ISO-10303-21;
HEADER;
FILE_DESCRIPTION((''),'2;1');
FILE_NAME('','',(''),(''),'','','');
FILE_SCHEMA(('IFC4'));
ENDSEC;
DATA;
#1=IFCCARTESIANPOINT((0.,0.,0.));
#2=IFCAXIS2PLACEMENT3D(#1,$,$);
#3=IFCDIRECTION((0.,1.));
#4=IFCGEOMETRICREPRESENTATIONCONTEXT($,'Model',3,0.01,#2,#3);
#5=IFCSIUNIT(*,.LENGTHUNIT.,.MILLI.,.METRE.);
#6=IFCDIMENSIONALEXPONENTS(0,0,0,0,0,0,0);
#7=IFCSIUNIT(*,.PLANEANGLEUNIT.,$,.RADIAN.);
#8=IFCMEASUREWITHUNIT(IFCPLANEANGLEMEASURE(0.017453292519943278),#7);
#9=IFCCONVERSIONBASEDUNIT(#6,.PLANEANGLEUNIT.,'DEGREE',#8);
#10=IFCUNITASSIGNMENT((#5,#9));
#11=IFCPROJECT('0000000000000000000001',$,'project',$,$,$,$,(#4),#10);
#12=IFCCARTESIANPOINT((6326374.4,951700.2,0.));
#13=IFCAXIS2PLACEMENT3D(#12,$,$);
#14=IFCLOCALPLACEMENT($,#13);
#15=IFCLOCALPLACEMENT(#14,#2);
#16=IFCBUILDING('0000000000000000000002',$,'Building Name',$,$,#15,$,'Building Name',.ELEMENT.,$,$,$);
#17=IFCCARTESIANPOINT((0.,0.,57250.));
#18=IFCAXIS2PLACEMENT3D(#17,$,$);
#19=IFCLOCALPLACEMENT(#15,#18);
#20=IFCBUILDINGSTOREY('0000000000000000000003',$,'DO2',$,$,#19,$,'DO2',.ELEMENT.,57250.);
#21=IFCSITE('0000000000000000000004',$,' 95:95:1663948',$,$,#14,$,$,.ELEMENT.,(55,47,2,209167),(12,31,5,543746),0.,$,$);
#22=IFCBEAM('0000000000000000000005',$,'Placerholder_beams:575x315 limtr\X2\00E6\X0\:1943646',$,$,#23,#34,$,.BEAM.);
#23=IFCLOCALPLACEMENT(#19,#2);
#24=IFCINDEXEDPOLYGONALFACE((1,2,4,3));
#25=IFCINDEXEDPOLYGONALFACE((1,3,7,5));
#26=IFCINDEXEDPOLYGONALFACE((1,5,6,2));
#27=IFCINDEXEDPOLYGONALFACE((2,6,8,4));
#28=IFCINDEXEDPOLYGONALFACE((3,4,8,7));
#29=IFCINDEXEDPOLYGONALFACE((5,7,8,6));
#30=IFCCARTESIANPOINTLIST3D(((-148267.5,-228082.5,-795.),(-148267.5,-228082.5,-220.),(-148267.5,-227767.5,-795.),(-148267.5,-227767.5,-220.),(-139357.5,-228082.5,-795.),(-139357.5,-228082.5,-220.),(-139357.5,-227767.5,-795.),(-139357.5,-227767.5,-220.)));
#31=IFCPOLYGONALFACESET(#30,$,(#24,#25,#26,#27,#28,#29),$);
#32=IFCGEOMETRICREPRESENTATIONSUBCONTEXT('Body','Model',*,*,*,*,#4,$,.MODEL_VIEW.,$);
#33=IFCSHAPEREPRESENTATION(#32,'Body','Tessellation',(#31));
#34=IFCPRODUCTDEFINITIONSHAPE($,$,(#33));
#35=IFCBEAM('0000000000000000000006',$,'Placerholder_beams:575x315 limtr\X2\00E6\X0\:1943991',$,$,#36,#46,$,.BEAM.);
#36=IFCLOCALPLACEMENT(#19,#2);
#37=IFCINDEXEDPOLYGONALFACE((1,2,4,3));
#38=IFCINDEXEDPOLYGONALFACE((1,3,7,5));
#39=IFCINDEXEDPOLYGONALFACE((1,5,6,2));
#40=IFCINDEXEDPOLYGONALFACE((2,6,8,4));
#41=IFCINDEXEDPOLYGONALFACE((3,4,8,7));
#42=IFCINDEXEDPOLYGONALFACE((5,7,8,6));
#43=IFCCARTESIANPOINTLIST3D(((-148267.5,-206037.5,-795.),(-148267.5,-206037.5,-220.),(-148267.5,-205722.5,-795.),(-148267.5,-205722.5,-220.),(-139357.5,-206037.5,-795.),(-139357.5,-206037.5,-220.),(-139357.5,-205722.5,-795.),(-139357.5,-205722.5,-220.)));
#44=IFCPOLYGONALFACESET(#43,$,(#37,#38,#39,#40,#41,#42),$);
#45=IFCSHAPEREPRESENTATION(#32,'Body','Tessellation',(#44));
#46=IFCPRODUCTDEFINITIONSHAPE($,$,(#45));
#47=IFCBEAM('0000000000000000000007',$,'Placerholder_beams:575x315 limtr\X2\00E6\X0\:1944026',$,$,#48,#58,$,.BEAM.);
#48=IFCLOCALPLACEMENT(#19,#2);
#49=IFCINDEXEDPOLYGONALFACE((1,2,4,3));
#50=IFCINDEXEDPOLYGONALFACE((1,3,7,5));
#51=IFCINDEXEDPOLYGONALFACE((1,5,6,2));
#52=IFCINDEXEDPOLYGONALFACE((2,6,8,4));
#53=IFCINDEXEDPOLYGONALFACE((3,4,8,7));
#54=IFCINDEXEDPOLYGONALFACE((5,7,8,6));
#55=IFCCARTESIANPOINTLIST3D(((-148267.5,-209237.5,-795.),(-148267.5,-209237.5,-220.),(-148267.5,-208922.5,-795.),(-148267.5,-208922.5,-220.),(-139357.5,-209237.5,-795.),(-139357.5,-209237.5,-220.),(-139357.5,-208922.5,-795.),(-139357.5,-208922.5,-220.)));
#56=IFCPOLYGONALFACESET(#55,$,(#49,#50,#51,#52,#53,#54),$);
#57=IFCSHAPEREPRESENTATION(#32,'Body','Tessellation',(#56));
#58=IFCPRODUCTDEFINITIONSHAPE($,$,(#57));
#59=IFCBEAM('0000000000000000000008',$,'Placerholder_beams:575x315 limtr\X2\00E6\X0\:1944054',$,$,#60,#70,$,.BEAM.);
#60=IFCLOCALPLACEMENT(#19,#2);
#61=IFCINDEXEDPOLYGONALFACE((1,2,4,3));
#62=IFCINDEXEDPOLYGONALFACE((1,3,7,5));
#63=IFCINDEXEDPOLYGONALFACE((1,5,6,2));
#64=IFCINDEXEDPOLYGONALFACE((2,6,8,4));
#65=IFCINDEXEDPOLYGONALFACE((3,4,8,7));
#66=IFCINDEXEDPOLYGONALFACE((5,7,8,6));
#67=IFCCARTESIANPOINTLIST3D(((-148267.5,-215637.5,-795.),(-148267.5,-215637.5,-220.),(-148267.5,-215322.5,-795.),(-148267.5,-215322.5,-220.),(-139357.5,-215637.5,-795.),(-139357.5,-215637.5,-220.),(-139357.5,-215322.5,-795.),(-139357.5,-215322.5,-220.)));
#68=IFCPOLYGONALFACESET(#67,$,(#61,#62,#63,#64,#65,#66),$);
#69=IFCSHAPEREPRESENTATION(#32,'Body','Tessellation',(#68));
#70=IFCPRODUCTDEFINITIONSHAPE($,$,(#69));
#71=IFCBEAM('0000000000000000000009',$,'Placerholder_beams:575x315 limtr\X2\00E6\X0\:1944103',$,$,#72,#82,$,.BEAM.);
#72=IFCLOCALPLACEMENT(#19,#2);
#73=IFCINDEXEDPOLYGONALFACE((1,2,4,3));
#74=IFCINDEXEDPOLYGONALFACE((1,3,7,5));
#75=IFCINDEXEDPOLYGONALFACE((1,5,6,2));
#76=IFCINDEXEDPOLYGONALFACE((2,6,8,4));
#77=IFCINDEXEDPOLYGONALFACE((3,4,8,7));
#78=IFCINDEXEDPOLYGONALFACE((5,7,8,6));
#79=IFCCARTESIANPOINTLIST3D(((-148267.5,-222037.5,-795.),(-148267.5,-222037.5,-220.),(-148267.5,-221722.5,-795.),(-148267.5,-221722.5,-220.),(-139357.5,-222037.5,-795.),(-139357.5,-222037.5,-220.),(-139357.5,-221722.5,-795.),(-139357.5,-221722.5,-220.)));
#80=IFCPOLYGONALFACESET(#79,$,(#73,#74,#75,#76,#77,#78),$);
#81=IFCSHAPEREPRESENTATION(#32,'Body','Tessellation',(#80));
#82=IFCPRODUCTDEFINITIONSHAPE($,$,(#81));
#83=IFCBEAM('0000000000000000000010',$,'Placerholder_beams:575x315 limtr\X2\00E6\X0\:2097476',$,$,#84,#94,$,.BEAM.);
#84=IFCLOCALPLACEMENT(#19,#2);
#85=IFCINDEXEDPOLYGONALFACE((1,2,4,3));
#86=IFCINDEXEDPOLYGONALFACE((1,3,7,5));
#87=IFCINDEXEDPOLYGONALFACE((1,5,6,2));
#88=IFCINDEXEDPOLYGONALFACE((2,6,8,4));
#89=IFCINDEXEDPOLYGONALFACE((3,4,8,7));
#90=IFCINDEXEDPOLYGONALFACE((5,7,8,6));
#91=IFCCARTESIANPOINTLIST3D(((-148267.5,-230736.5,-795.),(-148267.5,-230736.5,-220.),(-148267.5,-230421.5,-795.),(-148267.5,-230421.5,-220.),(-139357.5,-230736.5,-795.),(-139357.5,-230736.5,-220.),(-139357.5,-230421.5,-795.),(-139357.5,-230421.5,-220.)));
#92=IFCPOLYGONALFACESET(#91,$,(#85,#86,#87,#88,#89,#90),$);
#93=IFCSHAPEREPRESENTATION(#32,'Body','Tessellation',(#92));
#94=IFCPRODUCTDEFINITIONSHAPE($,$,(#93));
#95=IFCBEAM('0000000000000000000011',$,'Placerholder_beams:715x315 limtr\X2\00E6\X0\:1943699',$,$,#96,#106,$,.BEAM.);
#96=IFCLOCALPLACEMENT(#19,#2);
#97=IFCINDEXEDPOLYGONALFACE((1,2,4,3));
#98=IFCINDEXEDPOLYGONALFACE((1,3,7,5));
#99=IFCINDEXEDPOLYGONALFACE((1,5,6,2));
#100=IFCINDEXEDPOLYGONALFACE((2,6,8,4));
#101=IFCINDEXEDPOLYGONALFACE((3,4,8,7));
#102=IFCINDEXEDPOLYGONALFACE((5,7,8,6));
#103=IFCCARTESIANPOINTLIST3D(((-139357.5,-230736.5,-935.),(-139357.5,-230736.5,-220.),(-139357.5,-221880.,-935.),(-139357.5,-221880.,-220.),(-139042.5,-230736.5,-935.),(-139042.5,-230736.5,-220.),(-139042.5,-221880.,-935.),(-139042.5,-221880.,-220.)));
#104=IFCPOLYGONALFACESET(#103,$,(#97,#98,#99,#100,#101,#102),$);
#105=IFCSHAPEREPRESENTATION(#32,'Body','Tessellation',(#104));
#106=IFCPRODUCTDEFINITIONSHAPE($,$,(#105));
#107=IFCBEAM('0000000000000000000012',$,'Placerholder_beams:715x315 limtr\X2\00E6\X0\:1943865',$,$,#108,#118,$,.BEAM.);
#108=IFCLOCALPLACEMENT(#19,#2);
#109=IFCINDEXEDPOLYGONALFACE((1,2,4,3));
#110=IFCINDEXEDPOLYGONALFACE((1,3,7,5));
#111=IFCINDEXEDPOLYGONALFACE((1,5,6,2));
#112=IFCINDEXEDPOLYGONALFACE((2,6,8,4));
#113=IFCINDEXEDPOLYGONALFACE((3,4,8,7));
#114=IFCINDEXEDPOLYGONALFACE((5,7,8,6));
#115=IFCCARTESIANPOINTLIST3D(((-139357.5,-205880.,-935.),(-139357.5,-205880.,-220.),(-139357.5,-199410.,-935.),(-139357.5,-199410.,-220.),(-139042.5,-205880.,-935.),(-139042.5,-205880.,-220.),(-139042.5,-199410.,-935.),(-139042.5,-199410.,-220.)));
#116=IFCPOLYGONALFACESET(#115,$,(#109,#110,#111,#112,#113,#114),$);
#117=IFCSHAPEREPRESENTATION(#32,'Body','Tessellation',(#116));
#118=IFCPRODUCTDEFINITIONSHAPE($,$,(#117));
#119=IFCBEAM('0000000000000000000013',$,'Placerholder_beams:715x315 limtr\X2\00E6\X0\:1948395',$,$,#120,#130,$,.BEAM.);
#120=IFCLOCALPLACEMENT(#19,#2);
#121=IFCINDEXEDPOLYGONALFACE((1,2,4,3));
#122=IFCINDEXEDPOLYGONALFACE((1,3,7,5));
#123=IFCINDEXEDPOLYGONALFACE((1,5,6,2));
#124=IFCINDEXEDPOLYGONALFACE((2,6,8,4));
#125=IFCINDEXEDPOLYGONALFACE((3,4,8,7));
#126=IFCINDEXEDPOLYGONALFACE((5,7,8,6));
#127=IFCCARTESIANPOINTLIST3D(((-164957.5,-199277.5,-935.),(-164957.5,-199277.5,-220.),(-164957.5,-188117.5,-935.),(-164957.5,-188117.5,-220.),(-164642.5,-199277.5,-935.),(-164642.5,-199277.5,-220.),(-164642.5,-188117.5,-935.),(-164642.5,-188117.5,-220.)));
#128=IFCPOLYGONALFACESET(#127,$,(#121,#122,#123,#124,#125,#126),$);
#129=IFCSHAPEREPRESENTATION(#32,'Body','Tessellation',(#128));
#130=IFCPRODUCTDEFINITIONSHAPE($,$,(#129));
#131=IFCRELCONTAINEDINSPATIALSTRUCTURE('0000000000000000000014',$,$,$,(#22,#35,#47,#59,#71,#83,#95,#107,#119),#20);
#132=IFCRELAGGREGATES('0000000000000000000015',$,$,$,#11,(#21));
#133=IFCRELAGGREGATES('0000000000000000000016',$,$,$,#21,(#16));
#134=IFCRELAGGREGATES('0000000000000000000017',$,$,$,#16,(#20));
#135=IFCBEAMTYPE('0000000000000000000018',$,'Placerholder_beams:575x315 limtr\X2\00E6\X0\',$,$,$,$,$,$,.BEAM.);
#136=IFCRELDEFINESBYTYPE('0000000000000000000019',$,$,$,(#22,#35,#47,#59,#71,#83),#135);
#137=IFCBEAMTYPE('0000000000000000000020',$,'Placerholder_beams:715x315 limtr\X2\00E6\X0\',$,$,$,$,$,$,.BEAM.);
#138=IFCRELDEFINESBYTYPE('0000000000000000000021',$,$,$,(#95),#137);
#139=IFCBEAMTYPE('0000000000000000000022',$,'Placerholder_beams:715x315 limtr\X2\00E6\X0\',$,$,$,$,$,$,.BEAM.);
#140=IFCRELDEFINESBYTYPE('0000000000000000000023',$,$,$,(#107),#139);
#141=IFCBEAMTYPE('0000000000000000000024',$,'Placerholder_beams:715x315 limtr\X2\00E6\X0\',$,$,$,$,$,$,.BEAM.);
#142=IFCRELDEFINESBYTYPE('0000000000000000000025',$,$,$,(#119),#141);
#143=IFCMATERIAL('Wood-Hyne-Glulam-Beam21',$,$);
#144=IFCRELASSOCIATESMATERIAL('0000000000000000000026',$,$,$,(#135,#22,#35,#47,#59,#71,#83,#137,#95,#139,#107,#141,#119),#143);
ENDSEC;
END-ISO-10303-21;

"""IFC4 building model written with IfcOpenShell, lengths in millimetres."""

from ifc_helpers import new_model, entity, si_unit, converted_unit, direction, frame, origin, place, context, subcontext, project, spatial, indexed_curve, outline, extrude, source, transform, mapped, material, type_object, type_shapes, element, save


model = new_model("IFC4")

# Units and contexts
model_context = context("Model", 3, precision=0.01, world=origin(), true_north=direction((0.0, 1.0)))
body_context = subcontext(model_context, "Body", "Model", "MODEL_VIEW")
ifc_project = project(units=[si_unit("LENGTHUNIT", "METRE", prefix="MILLI"), converted_unit("PLANEANGLEUNIT", "DEGREE", entity("IfcPlaneAngleMeasure", 0.017453292519943278), si_unit("PLANEANGLEUNIT", "RADIAN"), dimensions=[0, 0, 0, 0, 0, 0, 0])], contexts=[model_context])

# Site, building, storey
site_placement = place(None, frame((6326374.4, 951700.2, 0.0)))
site = spatial("IfcSite", under=ifc_project, at=site_placement, Name=" 95:95:1663948", CompositionType="ELEMENT", RefLatitude=(55, 47, 2, 209167), RefLongitude=(12, 31, 5, 543746), RefElevation=0.0)
building_placement = place(site_placement, origin())
building = spatial("IfcBuilding", under=site, at=building_placement, Name="Building Name", LongName="Building Name", CompositionType="ELEMENT")
storey_placement = place(building_placement, frame((0.0, 0.0, 57250.0)))
storey = spatial("IfcBuildingStorey", under=building, at=storey_placement, Name="DO2", LongName="DO2", CompositionType="ELEMENT", Elevation=57250.0)

# Beams
ifc_material = material(Name="Wood-Hyne-Glulam-Beam21")
beam_type_1 = type_object("IfcBeamType", Name="Placerholder_beams:575x315 limtræ", PredefinedType="BEAM", material=ifc_material)
shared_shape_1 = source(origin(), body_context, "Body", "SweptSolid", [
    extrude(outline(indexed_curve([(-4455.0, -157.5), (4455.0, -157.5), (4455.0, 157.5), (-4455.0, 157.5), (-4455.0, -157.5)], self_intersect=False)), frame((0.0, 0.0, -287.5)), (0.0, 0.0, 1.0), 575.0),
])
type_shapes(beam_type_1, [shared_shape_1])
for number, where, name in (
    (1, (-143812.5, -227925.0, -507.5), "Placerholder_beams:575x315 limtræ:1943646"),
    (2, (-143812.5, -205880.0, -507.5), "Placerholder_beams:575x315 limtræ:1943991"),
    (3, (-143812.5, -209080.0, -507.5), "Placerholder_beams:575x315 limtræ:1944026"),
    (4, (-143812.5, -215480.0, -507.5), "Placerholder_beams:575x315 limtræ:1944054"),
    (5, (-143812.5, -221880.0, -507.5), "Placerholder_beams:575x315 limtræ:1944103"),
    (6, (-143812.5, -230579.0, -507.5), "Placerholder_beams:575x315 limtræ:2097476"),
):
    element("IfcBeam", number, at=place(storey_placement, frame(where)), inside=storey, type_object=beam_type_1, material=ifc_material, Name=name, PredefinedType="BEAM", context=body_context, shape_type="MappedRepresentation", body=[
        mapped(shared_shape_1, transform((0.0, 0.0, 0.0), scale=1.0)),
    ])
beam_type_2 = type_object("IfcBeamType", Name="Placerholder_beams:715x315 limtræ", PredefinedType="BEAM", material=ifc_material)
shared_shape_2 = source(origin(), body_context, "Body", "SweptSolid", [
    extrude(outline(indexed_curve([(-4428.2, -157.5), (4428.2, -157.5), (4428.2, 157.5), (-4428.2, 157.5), (-4428.2, -157.5)], self_intersect=False)), frame((-78.8, 0.0, -357.5)), (0.0, 0.0, 1.0), 715.0),
])
type_shapes(beam_type_2, [shared_shape_2])
beam_1_placement = place(storey_placement, frame((-139200.0, -226229.5, -577.5), z_axis=(0.0, 0.0, 1.0), x_axis=(0.0, 1.0, 0.0)))
element("IfcBeam", 7, at=beam_1_placement, inside=storey, type_object=beam_type_2, material=ifc_material, Name="Placerholder_beams:715x315 limtræ:1943699", PredefinedType="BEAM", context=body_context, shape_type="MappedRepresentation", body=[
    mapped(shared_shape_2, transform((0.0, 0.0, 0.0), scale=1.0)),
])
beam_type_3 = type_object("IfcBeamType", Name="Placerholder_beams:715x315 limtræ", PredefinedType="BEAM", material=ifc_material)
shared_shape_3 = source(origin(), body_context, "Body", "SweptSolid", [
    extrude(outline(indexed_curve([(-3235.0, -157.5), (3235.0, -157.5), (3235.0, 157.5), (-3235.0, 157.5), (-3235.0, -157.5)], self_intersect=False)), frame((-1565.0, 0.0, -357.5)), (0.0, 0.0, 1.0), 715.0),
])
type_shapes(beam_type_3, [shared_shape_3])
beam_2_placement = place(storey_placement, frame((-139200.0, -201080.0, -577.5), z_axis=(0.0, 0.0, 1.0), x_axis=(0.0, 1.0, 0.0)))
element("IfcBeam", 8, at=beam_2_placement, inside=storey, type_object=beam_type_3, material=ifc_material, Name="Placerholder_beams:715x315 limtræ:1943865", PredefinedType="BEAM", context=body_context, shape_type="MappedRepresentation", body=[
    mapped(shared_shape_3, transform((0.0, 0.0, 0.0), scale=1.0)),
])
beam_type_4 = type_object("IfcBeamType", Name="Placerholder_beams:715x315 limtræ", PredefinedType="BEAM", material=ifc_material)
shared_shape_4 = source(origin(), body_context, "Body", "SweptSolid", [
    extrude(outline(indexed_curve([(-5580.0, -157.5), (5580.0, -157.5), (5580.0, 157.5), (-5580.0, 157.5), (-5580.0, -157.5)], self_intersect=False)), frame((0.0, 0.0, -357.5)), (0.0, 0.0, 1.0), 715.0),
])
type_shapes(beam_type_4, [shared_shape_4])
beam_3_placement = place(storey_placement, frame((-164800.0, -193697.5, -577.5), z_axis=(0.0, 0.0, 1.0), x_axis=(0.0, -1.0, 0.0)))
element("IfcBeam", 9, at=beam_3_placement, inside=storey, type_object=beam_type_4, material=ifc_material, Name="Placerholder_beams:715x315 limtræ:1948395", PredefinedType="BEAM", context=body_context, shape_type="MappedRepresentation", body=[
    mapped(shared_shape_4, transform((0.0, 0.0, 0.0), scale=1.0)),
])

save(model, "model.ifc")
